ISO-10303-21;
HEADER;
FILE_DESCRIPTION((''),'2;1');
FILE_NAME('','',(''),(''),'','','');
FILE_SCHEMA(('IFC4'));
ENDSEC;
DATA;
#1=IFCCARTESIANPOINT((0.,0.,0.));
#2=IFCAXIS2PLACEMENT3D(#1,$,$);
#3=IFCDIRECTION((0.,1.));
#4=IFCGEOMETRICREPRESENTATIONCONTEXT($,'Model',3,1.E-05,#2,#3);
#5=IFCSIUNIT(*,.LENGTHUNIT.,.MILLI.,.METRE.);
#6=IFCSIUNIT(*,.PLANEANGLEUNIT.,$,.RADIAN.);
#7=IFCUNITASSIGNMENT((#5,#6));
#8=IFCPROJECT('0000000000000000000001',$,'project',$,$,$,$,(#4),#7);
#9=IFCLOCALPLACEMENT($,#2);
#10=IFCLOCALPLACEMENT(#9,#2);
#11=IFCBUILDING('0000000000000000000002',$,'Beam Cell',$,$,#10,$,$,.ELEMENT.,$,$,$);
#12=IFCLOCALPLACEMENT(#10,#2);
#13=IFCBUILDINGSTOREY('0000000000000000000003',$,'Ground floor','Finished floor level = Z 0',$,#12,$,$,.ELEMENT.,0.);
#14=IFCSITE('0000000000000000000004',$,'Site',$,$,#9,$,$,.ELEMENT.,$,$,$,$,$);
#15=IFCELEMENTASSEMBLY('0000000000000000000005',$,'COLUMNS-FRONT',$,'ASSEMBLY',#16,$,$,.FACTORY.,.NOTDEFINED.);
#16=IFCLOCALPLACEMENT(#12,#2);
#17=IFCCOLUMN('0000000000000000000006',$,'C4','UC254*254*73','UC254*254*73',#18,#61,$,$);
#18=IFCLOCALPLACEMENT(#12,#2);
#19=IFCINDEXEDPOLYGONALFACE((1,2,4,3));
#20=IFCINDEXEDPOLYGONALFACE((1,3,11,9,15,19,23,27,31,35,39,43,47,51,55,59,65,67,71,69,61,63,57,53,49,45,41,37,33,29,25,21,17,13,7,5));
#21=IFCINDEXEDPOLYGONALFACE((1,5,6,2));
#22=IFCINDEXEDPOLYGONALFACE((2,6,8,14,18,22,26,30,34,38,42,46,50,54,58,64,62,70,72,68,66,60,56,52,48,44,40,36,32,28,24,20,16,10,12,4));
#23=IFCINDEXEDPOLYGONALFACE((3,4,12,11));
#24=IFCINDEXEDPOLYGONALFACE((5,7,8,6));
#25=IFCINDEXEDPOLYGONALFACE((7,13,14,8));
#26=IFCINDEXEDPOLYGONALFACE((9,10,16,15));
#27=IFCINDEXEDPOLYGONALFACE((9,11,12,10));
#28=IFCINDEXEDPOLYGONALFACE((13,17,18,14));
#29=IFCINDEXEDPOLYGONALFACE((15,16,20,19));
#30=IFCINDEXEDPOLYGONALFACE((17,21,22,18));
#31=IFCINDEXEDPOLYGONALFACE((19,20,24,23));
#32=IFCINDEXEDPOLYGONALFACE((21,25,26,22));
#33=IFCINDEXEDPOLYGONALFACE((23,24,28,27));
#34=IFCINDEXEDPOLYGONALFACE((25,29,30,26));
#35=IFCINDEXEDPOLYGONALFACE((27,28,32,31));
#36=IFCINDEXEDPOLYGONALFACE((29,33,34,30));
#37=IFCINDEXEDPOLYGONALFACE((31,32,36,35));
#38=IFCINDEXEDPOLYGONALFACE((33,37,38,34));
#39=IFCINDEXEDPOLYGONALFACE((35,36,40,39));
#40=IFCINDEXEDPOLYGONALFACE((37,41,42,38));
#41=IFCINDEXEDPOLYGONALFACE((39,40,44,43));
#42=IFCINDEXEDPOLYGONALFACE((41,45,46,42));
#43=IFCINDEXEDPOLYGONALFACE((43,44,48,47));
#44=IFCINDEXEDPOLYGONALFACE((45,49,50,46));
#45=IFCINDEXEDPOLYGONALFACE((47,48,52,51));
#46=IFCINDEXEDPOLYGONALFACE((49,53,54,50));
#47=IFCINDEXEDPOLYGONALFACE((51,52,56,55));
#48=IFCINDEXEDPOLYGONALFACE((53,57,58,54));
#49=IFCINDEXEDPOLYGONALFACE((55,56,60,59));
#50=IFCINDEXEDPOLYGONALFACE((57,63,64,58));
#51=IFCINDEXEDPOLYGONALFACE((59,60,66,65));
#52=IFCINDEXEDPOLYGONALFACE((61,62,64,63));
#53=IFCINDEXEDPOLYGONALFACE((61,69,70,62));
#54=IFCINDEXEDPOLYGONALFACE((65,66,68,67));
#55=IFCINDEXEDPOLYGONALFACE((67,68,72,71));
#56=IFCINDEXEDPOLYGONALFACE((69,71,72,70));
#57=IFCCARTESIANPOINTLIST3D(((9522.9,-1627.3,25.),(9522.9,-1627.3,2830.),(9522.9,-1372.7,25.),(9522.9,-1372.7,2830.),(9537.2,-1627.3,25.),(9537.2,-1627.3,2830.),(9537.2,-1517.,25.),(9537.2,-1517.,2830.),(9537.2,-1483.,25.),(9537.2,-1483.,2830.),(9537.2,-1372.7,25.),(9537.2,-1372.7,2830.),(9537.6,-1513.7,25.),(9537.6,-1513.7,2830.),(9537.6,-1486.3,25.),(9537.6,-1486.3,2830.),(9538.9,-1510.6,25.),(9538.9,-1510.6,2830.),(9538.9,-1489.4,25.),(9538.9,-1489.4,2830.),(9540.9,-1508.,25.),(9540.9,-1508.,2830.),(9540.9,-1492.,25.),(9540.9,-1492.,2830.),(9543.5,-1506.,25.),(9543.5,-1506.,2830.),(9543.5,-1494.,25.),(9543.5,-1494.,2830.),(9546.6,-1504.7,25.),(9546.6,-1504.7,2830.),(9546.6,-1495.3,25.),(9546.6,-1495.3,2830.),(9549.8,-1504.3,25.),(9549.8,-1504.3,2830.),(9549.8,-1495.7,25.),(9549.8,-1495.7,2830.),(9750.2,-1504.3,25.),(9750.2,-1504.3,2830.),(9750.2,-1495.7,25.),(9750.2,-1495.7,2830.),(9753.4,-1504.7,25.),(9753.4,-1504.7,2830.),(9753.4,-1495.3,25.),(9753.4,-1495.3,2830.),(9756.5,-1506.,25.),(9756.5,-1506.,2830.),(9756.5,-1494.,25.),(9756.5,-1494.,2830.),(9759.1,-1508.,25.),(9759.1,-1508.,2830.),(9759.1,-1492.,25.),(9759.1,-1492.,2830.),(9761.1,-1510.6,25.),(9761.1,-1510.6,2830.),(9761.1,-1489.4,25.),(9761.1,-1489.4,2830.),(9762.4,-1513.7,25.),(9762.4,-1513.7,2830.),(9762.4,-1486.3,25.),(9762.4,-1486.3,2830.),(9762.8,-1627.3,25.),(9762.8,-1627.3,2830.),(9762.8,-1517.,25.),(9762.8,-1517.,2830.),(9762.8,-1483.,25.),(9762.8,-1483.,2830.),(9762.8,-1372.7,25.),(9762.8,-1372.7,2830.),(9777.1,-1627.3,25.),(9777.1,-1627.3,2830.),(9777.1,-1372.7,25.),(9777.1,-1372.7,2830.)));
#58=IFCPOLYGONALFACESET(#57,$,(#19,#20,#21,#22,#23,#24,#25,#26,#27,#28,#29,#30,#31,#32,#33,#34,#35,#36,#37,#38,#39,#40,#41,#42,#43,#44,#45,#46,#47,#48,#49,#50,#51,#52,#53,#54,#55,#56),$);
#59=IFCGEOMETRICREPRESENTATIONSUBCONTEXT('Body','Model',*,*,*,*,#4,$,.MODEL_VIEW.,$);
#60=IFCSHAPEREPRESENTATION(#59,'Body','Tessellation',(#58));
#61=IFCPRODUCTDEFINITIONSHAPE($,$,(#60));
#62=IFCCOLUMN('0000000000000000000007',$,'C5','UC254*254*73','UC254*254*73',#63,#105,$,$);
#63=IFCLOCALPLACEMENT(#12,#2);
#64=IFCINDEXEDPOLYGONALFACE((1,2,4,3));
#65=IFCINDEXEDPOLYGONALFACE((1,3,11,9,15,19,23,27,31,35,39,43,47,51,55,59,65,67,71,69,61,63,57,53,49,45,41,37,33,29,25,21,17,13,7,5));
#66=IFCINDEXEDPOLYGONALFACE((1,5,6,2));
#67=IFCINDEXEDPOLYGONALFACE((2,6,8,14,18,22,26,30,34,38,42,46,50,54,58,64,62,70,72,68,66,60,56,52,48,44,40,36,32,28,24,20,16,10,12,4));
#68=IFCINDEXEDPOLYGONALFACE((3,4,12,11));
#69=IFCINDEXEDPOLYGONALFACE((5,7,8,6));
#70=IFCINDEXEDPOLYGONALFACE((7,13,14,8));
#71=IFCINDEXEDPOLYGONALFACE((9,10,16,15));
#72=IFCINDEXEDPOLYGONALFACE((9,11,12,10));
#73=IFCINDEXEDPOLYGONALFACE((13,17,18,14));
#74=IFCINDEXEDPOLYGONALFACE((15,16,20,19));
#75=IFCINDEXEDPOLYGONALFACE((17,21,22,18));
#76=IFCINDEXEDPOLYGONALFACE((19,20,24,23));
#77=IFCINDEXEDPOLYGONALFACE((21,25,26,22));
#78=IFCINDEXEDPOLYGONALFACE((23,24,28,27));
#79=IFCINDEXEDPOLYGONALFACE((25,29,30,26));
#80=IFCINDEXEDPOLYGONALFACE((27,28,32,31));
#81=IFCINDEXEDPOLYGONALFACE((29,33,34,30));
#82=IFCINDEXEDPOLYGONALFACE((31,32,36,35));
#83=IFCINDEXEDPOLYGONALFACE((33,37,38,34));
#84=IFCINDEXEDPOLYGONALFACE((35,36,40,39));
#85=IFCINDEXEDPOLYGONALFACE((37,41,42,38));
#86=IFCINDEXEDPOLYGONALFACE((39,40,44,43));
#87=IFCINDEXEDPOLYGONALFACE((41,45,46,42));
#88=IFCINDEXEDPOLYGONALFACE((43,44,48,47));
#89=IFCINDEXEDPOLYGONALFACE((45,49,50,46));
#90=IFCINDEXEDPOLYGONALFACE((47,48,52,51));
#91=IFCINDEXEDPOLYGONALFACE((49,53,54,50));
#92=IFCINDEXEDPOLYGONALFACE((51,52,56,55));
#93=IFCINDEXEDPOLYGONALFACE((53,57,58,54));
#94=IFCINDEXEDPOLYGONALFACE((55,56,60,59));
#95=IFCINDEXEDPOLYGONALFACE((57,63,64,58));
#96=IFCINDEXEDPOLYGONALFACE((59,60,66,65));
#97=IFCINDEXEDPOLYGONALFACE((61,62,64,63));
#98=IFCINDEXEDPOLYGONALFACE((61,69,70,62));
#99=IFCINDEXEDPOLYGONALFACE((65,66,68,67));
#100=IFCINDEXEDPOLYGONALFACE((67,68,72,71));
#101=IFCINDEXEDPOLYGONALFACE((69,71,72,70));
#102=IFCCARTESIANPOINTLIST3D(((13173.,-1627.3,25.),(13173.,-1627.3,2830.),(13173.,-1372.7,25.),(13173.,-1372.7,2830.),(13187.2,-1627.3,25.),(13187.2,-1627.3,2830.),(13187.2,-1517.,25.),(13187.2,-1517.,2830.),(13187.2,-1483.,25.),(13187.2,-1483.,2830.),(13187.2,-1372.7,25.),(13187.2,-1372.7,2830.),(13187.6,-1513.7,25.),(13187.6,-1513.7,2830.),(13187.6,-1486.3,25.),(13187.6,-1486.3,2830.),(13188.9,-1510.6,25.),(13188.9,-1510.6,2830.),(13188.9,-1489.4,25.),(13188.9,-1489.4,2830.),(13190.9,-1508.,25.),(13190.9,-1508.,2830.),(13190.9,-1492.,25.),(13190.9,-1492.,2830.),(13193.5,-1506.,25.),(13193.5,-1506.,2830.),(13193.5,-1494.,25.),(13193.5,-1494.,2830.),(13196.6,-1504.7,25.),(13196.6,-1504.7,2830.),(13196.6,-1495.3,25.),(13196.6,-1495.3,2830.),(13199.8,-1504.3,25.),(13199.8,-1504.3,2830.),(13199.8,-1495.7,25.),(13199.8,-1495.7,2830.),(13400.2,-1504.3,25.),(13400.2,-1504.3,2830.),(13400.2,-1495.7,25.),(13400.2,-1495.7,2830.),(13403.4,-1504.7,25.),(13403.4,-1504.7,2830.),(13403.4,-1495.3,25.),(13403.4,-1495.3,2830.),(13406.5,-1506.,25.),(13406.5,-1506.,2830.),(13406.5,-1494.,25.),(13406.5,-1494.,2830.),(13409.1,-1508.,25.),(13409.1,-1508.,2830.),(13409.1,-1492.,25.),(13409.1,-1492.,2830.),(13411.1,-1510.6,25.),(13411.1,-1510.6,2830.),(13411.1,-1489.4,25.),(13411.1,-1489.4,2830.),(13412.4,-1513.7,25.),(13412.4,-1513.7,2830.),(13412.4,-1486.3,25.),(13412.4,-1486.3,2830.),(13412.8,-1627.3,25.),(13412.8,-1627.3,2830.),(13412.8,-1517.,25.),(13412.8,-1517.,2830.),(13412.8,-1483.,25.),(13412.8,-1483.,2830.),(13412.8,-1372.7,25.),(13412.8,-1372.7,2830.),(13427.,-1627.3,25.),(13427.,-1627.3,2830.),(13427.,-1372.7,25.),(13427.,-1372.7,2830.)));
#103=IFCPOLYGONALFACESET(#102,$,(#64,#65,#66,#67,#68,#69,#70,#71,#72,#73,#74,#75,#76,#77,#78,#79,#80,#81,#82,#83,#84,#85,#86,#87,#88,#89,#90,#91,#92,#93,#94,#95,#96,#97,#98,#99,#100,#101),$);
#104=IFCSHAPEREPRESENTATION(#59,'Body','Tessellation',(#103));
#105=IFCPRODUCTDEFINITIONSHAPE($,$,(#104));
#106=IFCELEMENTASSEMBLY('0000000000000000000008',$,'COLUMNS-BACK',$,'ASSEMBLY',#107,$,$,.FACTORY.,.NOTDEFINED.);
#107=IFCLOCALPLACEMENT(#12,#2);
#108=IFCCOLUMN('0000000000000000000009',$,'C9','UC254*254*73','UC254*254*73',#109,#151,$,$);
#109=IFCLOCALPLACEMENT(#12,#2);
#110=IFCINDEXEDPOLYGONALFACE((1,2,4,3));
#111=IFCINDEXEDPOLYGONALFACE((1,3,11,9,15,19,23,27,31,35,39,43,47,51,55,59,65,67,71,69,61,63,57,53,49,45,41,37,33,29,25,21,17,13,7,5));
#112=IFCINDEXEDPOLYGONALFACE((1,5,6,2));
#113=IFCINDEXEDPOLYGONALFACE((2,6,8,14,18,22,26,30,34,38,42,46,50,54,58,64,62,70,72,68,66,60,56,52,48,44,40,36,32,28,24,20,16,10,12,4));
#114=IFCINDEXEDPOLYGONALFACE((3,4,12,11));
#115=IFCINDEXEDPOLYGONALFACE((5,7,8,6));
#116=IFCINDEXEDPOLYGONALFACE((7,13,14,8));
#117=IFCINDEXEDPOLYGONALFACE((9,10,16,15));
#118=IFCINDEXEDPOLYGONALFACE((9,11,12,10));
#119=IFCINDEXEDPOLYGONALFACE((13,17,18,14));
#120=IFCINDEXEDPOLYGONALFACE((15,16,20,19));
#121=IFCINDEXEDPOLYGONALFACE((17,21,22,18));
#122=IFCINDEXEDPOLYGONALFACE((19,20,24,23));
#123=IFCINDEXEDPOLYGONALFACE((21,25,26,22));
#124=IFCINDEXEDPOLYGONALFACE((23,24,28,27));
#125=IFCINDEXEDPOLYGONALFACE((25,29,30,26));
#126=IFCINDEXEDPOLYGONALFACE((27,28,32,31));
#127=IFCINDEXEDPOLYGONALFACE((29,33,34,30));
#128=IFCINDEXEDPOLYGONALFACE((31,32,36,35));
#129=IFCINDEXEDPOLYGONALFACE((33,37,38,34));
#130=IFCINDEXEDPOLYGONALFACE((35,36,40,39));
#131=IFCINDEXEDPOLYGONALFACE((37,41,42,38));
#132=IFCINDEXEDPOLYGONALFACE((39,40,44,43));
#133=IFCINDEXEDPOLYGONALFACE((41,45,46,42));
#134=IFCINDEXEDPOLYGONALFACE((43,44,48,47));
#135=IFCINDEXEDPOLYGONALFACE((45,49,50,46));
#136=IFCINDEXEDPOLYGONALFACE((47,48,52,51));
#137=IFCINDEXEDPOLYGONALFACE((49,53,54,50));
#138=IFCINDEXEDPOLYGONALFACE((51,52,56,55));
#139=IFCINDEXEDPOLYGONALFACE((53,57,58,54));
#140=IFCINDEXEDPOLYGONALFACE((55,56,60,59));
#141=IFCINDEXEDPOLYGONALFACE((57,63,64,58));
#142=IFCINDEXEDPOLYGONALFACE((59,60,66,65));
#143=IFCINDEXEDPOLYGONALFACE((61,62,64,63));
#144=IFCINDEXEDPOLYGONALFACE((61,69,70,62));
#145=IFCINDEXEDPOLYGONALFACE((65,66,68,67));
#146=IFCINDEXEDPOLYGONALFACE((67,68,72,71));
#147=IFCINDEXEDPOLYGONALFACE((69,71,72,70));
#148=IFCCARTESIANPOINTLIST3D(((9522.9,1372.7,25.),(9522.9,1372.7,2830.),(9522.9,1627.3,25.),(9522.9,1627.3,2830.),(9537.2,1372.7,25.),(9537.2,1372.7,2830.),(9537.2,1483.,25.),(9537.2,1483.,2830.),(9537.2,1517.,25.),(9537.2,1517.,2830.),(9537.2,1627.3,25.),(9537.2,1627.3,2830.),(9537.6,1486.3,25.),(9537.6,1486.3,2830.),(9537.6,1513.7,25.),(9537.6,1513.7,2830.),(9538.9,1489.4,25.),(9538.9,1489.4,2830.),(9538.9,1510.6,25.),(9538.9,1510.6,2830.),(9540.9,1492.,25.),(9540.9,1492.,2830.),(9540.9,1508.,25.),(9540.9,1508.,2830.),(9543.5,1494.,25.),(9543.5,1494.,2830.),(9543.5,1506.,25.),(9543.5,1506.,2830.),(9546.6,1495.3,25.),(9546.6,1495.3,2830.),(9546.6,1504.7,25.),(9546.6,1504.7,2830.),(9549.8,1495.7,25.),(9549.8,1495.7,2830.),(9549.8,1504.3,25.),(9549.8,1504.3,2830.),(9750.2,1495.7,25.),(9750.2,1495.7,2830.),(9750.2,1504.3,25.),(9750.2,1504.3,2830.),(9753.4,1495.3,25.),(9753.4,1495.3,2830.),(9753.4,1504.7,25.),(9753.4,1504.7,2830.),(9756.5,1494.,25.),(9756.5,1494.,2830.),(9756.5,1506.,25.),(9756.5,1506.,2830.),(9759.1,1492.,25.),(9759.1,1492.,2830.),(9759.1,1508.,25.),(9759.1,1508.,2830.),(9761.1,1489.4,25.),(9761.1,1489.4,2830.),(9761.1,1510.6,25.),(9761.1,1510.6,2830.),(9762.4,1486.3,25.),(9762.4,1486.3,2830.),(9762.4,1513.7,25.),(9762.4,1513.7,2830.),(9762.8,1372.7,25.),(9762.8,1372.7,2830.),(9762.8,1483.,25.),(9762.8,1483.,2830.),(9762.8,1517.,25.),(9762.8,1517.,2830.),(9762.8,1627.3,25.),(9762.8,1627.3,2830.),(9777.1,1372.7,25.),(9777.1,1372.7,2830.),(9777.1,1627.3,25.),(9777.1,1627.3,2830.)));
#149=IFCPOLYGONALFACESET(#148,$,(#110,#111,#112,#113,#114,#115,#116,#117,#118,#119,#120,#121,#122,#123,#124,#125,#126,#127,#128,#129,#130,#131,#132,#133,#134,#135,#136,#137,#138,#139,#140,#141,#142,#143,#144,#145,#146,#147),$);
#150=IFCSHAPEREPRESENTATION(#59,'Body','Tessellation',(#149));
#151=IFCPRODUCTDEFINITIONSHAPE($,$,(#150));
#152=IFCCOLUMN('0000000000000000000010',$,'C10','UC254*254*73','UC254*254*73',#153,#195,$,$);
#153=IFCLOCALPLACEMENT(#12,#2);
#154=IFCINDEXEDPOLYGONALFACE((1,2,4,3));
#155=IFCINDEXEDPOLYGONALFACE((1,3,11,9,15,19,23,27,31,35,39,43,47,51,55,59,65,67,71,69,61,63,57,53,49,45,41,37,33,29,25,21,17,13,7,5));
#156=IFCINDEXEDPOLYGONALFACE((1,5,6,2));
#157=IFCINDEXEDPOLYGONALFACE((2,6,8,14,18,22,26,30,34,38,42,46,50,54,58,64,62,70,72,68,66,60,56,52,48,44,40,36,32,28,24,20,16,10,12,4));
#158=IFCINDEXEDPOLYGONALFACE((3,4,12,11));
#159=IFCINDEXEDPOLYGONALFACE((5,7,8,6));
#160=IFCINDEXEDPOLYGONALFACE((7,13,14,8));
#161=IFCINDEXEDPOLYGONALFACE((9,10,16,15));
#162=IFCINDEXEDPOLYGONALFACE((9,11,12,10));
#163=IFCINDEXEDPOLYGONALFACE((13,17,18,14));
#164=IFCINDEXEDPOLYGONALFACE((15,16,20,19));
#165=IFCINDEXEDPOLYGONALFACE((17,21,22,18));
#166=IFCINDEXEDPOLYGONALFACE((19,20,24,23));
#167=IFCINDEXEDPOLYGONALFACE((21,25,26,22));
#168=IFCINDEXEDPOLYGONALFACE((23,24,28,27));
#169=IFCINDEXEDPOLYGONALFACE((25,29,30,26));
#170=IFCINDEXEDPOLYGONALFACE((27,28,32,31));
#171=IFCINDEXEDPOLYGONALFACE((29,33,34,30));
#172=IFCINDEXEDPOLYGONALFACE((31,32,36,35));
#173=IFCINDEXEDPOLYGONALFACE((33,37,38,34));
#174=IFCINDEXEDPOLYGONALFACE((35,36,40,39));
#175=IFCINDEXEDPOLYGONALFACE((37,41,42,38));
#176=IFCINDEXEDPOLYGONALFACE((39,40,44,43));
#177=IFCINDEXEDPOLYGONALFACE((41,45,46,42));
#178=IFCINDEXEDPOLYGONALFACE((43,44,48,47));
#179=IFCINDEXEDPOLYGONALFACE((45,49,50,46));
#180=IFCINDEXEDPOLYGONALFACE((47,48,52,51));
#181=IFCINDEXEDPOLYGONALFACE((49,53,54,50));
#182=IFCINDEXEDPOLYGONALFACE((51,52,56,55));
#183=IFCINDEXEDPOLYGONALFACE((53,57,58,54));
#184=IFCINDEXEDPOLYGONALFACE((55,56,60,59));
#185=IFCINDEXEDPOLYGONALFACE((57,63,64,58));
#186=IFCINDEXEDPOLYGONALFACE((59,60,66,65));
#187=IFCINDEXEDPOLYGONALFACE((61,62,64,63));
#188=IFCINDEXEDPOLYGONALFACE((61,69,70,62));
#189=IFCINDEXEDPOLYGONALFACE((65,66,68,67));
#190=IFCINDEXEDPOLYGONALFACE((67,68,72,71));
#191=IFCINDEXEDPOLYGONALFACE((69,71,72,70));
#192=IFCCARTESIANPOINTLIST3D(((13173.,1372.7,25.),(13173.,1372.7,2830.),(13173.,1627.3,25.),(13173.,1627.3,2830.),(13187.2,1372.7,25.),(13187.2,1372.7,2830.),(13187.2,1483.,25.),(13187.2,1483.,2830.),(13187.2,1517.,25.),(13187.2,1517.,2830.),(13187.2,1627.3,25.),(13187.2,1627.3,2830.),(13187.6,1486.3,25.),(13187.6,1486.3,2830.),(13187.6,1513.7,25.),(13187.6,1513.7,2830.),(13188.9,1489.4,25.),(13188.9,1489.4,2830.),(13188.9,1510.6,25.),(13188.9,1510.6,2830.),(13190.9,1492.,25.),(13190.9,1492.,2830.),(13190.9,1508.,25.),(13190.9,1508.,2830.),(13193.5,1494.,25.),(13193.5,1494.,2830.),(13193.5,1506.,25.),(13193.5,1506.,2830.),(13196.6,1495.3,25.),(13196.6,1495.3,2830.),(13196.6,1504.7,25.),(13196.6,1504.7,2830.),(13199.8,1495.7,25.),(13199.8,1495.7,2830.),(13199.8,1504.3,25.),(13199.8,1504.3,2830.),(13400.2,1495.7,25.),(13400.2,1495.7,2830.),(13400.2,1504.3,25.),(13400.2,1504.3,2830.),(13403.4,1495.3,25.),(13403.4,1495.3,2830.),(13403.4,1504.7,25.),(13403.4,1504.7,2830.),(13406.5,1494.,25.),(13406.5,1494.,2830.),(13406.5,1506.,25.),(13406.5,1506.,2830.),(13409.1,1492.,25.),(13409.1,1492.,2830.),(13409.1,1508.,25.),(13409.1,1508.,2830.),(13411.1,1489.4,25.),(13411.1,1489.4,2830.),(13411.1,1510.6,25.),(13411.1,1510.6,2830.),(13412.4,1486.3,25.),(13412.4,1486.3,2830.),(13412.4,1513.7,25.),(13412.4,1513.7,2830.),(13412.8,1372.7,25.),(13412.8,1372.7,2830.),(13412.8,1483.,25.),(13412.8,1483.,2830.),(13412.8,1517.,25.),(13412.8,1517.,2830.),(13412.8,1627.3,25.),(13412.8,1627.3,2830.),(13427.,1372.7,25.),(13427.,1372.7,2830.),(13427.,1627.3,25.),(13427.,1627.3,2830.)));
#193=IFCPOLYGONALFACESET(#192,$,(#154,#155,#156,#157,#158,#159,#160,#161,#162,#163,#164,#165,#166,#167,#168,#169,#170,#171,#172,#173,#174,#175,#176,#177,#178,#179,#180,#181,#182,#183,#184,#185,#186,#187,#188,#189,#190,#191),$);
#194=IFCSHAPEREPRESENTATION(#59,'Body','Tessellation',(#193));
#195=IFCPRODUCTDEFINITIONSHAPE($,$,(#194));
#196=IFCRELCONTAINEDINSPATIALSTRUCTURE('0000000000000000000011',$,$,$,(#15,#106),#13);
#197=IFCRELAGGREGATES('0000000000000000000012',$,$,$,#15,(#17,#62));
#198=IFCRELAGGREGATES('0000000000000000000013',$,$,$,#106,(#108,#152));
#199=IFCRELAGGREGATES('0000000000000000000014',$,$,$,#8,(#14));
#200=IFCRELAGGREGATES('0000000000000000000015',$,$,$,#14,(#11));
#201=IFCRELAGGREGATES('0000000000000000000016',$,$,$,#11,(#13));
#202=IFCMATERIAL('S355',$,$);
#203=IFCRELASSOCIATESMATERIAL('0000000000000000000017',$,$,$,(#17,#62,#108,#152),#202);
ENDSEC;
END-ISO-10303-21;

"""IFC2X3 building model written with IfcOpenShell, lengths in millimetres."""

from ifc_helpers import new_model, si_unit, direction, frame, origin, origin_2d, place, context, subcontext, project, spatial, i_section, extrude, material, element, aggregate, save


model = new_model("IFC2X3")

# Units and contexts
model_context = context("Model", 3, precision=1e-05, world=origin(), true_north=direction((0.0, 1.0)))
body_context = subcontext(model_context, "Body", "Model", "MODEL_VIEW")
ifc_project = project(units=[si_unit("LENGTHUNIT", "METRE", prefix="MILLI"), si_unit("PLANEANGLEUNIT", "RADIAN")], contexts=[model_context])

# Site, building, storey
site_placement = place(None, origin())
site = spatial("IfcSite", under=ifc_project, at=site_placement, Name="Site", CompositionType="ELEMENT")
building_placement = place(site_placement, origin())
building = spatial("IfcBuilding", under=site, at=building_placement, Name="Beam Cell", CompositionType="ELEMENT")
storey_placement = place(building_placement, origin())
storey = spatial("IfcBuildingStorey", under=building, at=storey_placement, Name="Ground floor", Description="Finished floor level = Z 0", CompositionType="ELEMENT", Elevation=0.0)

# Element assemblies, columns
assembly_1_placement = place(storey_placement, origin())
assembly_1 = element("IfcElementAssembly", 1, at=assembly_1_placement, inside=storey, Name="COLUMNS-FRONT", ObjectType="ASSEMBLY", AssemblyPlace="FACTORY", PredefinedType="NOTDEFINED")
ifc_material = material(Name="S355")
column_1_placement = place(storey_placement, frame((9650.0, -1500.0, 25.0), z_axis=(0.0, 0.0, 1.0), x_axis=(0.0, 1.0, 0.0)))
column_1 = element("IfcColumn", 2, at=column_1_placement, material=ifc_material, Name="C4", Description="UC254*254*73", ObjectType="UC254*254*73", context=body_context, shape_type="SweptSolid", body=[
    extrude(i_section(OverallWidth=254.6, OverallDepth=254.1, WebThickness=8.6, FlangeThickness=14.2, FilletRadius=12.7, at=origin_2d()), origin(), (0.0, 0.0, 1.0), 2805.0),
])
column_2_placement = place(storey_placement, frame((13300.0, -1500.0, 25.0), z_axis=(0.0, 0.0, 1.0), x_axis=(0.0, 1.0, 0.0)))
column_2 = element("IfcColumn", 3, at=column_2_placement, material=ifc_material, Name="C5", Description="UC254*254*73", ObjectType="UC254*254*73", context=body_context, shape_type="SweptSolid", body=[
    extrude(i_section(OverallWidth=254.6, OverallDepth=254.1, WebThickness=8.6, FlangeThickness=14.2, FilletRadius=12.7, at=origin_2d()), origin(), (0.0, 0.0, 1.0), 2805.0),
])
assembly_2_placement = place(storey_placement, origin())
assembly_2 = element("IfcElementAssembly", 4, at=assembly_2_placement, inside=storey, Name="COLUMNS-BACK", ObjectType="ASSEMBLY", AssemblyPlace="FACTORY", PredefinedType="NOTDEFINED")
column_3_placement = place(storey_placement, frame((9650.0, 1500.0, 25.0), z_axis=(0.0, 0.0, 1.0), x_axis=(0.0, 1.0, 0.0)))
column_3 = element("IfcColumn", 5, at=column_3_placement, material=ifc_material, Name="C9", Description="UC254*254*73", ObjectType="UC254*254*73", context=body_context, shape_type="SweptSolid", body=[
    extrude(i_section(OverallWidth=254.6, OverallDepth=254.1, WebThickness=8.6, FlangeThickness=14.2, FilletRadius=12.7, at=origin_2d()), origin(), (0.0, 0.0, 1.0), 2805.0),
])
column_4_placement = place(storey_placement, frame((13300.0, 1500.0, 25.0), z_axis=(0.0, 0.0, 1.0), x_axis=(0.0, 1.0, 0.0)))
column_4 = element("IfcColumn", 6, at=column_4_placement, material=ifc_material, Name="C10", Description="UC254*254*73", ObjectType="UC254*254*73", context=body_context, shape_type="SweptSolid", body=[
    extrude(i_section(OverallWidth=254.6, OverallDepth=254.1, WebThickness=8.6, FlangeThickness=14.2, FilletRadius=12.7, at=origin_2d()), origin(), (0.0, 0.0, 1.0), 2805.0),
])

aggregate(assembly_1, [column_1, column_2])
aggregate(assembly_2, [column_3, column_4])

save(model, "model.ifc")
